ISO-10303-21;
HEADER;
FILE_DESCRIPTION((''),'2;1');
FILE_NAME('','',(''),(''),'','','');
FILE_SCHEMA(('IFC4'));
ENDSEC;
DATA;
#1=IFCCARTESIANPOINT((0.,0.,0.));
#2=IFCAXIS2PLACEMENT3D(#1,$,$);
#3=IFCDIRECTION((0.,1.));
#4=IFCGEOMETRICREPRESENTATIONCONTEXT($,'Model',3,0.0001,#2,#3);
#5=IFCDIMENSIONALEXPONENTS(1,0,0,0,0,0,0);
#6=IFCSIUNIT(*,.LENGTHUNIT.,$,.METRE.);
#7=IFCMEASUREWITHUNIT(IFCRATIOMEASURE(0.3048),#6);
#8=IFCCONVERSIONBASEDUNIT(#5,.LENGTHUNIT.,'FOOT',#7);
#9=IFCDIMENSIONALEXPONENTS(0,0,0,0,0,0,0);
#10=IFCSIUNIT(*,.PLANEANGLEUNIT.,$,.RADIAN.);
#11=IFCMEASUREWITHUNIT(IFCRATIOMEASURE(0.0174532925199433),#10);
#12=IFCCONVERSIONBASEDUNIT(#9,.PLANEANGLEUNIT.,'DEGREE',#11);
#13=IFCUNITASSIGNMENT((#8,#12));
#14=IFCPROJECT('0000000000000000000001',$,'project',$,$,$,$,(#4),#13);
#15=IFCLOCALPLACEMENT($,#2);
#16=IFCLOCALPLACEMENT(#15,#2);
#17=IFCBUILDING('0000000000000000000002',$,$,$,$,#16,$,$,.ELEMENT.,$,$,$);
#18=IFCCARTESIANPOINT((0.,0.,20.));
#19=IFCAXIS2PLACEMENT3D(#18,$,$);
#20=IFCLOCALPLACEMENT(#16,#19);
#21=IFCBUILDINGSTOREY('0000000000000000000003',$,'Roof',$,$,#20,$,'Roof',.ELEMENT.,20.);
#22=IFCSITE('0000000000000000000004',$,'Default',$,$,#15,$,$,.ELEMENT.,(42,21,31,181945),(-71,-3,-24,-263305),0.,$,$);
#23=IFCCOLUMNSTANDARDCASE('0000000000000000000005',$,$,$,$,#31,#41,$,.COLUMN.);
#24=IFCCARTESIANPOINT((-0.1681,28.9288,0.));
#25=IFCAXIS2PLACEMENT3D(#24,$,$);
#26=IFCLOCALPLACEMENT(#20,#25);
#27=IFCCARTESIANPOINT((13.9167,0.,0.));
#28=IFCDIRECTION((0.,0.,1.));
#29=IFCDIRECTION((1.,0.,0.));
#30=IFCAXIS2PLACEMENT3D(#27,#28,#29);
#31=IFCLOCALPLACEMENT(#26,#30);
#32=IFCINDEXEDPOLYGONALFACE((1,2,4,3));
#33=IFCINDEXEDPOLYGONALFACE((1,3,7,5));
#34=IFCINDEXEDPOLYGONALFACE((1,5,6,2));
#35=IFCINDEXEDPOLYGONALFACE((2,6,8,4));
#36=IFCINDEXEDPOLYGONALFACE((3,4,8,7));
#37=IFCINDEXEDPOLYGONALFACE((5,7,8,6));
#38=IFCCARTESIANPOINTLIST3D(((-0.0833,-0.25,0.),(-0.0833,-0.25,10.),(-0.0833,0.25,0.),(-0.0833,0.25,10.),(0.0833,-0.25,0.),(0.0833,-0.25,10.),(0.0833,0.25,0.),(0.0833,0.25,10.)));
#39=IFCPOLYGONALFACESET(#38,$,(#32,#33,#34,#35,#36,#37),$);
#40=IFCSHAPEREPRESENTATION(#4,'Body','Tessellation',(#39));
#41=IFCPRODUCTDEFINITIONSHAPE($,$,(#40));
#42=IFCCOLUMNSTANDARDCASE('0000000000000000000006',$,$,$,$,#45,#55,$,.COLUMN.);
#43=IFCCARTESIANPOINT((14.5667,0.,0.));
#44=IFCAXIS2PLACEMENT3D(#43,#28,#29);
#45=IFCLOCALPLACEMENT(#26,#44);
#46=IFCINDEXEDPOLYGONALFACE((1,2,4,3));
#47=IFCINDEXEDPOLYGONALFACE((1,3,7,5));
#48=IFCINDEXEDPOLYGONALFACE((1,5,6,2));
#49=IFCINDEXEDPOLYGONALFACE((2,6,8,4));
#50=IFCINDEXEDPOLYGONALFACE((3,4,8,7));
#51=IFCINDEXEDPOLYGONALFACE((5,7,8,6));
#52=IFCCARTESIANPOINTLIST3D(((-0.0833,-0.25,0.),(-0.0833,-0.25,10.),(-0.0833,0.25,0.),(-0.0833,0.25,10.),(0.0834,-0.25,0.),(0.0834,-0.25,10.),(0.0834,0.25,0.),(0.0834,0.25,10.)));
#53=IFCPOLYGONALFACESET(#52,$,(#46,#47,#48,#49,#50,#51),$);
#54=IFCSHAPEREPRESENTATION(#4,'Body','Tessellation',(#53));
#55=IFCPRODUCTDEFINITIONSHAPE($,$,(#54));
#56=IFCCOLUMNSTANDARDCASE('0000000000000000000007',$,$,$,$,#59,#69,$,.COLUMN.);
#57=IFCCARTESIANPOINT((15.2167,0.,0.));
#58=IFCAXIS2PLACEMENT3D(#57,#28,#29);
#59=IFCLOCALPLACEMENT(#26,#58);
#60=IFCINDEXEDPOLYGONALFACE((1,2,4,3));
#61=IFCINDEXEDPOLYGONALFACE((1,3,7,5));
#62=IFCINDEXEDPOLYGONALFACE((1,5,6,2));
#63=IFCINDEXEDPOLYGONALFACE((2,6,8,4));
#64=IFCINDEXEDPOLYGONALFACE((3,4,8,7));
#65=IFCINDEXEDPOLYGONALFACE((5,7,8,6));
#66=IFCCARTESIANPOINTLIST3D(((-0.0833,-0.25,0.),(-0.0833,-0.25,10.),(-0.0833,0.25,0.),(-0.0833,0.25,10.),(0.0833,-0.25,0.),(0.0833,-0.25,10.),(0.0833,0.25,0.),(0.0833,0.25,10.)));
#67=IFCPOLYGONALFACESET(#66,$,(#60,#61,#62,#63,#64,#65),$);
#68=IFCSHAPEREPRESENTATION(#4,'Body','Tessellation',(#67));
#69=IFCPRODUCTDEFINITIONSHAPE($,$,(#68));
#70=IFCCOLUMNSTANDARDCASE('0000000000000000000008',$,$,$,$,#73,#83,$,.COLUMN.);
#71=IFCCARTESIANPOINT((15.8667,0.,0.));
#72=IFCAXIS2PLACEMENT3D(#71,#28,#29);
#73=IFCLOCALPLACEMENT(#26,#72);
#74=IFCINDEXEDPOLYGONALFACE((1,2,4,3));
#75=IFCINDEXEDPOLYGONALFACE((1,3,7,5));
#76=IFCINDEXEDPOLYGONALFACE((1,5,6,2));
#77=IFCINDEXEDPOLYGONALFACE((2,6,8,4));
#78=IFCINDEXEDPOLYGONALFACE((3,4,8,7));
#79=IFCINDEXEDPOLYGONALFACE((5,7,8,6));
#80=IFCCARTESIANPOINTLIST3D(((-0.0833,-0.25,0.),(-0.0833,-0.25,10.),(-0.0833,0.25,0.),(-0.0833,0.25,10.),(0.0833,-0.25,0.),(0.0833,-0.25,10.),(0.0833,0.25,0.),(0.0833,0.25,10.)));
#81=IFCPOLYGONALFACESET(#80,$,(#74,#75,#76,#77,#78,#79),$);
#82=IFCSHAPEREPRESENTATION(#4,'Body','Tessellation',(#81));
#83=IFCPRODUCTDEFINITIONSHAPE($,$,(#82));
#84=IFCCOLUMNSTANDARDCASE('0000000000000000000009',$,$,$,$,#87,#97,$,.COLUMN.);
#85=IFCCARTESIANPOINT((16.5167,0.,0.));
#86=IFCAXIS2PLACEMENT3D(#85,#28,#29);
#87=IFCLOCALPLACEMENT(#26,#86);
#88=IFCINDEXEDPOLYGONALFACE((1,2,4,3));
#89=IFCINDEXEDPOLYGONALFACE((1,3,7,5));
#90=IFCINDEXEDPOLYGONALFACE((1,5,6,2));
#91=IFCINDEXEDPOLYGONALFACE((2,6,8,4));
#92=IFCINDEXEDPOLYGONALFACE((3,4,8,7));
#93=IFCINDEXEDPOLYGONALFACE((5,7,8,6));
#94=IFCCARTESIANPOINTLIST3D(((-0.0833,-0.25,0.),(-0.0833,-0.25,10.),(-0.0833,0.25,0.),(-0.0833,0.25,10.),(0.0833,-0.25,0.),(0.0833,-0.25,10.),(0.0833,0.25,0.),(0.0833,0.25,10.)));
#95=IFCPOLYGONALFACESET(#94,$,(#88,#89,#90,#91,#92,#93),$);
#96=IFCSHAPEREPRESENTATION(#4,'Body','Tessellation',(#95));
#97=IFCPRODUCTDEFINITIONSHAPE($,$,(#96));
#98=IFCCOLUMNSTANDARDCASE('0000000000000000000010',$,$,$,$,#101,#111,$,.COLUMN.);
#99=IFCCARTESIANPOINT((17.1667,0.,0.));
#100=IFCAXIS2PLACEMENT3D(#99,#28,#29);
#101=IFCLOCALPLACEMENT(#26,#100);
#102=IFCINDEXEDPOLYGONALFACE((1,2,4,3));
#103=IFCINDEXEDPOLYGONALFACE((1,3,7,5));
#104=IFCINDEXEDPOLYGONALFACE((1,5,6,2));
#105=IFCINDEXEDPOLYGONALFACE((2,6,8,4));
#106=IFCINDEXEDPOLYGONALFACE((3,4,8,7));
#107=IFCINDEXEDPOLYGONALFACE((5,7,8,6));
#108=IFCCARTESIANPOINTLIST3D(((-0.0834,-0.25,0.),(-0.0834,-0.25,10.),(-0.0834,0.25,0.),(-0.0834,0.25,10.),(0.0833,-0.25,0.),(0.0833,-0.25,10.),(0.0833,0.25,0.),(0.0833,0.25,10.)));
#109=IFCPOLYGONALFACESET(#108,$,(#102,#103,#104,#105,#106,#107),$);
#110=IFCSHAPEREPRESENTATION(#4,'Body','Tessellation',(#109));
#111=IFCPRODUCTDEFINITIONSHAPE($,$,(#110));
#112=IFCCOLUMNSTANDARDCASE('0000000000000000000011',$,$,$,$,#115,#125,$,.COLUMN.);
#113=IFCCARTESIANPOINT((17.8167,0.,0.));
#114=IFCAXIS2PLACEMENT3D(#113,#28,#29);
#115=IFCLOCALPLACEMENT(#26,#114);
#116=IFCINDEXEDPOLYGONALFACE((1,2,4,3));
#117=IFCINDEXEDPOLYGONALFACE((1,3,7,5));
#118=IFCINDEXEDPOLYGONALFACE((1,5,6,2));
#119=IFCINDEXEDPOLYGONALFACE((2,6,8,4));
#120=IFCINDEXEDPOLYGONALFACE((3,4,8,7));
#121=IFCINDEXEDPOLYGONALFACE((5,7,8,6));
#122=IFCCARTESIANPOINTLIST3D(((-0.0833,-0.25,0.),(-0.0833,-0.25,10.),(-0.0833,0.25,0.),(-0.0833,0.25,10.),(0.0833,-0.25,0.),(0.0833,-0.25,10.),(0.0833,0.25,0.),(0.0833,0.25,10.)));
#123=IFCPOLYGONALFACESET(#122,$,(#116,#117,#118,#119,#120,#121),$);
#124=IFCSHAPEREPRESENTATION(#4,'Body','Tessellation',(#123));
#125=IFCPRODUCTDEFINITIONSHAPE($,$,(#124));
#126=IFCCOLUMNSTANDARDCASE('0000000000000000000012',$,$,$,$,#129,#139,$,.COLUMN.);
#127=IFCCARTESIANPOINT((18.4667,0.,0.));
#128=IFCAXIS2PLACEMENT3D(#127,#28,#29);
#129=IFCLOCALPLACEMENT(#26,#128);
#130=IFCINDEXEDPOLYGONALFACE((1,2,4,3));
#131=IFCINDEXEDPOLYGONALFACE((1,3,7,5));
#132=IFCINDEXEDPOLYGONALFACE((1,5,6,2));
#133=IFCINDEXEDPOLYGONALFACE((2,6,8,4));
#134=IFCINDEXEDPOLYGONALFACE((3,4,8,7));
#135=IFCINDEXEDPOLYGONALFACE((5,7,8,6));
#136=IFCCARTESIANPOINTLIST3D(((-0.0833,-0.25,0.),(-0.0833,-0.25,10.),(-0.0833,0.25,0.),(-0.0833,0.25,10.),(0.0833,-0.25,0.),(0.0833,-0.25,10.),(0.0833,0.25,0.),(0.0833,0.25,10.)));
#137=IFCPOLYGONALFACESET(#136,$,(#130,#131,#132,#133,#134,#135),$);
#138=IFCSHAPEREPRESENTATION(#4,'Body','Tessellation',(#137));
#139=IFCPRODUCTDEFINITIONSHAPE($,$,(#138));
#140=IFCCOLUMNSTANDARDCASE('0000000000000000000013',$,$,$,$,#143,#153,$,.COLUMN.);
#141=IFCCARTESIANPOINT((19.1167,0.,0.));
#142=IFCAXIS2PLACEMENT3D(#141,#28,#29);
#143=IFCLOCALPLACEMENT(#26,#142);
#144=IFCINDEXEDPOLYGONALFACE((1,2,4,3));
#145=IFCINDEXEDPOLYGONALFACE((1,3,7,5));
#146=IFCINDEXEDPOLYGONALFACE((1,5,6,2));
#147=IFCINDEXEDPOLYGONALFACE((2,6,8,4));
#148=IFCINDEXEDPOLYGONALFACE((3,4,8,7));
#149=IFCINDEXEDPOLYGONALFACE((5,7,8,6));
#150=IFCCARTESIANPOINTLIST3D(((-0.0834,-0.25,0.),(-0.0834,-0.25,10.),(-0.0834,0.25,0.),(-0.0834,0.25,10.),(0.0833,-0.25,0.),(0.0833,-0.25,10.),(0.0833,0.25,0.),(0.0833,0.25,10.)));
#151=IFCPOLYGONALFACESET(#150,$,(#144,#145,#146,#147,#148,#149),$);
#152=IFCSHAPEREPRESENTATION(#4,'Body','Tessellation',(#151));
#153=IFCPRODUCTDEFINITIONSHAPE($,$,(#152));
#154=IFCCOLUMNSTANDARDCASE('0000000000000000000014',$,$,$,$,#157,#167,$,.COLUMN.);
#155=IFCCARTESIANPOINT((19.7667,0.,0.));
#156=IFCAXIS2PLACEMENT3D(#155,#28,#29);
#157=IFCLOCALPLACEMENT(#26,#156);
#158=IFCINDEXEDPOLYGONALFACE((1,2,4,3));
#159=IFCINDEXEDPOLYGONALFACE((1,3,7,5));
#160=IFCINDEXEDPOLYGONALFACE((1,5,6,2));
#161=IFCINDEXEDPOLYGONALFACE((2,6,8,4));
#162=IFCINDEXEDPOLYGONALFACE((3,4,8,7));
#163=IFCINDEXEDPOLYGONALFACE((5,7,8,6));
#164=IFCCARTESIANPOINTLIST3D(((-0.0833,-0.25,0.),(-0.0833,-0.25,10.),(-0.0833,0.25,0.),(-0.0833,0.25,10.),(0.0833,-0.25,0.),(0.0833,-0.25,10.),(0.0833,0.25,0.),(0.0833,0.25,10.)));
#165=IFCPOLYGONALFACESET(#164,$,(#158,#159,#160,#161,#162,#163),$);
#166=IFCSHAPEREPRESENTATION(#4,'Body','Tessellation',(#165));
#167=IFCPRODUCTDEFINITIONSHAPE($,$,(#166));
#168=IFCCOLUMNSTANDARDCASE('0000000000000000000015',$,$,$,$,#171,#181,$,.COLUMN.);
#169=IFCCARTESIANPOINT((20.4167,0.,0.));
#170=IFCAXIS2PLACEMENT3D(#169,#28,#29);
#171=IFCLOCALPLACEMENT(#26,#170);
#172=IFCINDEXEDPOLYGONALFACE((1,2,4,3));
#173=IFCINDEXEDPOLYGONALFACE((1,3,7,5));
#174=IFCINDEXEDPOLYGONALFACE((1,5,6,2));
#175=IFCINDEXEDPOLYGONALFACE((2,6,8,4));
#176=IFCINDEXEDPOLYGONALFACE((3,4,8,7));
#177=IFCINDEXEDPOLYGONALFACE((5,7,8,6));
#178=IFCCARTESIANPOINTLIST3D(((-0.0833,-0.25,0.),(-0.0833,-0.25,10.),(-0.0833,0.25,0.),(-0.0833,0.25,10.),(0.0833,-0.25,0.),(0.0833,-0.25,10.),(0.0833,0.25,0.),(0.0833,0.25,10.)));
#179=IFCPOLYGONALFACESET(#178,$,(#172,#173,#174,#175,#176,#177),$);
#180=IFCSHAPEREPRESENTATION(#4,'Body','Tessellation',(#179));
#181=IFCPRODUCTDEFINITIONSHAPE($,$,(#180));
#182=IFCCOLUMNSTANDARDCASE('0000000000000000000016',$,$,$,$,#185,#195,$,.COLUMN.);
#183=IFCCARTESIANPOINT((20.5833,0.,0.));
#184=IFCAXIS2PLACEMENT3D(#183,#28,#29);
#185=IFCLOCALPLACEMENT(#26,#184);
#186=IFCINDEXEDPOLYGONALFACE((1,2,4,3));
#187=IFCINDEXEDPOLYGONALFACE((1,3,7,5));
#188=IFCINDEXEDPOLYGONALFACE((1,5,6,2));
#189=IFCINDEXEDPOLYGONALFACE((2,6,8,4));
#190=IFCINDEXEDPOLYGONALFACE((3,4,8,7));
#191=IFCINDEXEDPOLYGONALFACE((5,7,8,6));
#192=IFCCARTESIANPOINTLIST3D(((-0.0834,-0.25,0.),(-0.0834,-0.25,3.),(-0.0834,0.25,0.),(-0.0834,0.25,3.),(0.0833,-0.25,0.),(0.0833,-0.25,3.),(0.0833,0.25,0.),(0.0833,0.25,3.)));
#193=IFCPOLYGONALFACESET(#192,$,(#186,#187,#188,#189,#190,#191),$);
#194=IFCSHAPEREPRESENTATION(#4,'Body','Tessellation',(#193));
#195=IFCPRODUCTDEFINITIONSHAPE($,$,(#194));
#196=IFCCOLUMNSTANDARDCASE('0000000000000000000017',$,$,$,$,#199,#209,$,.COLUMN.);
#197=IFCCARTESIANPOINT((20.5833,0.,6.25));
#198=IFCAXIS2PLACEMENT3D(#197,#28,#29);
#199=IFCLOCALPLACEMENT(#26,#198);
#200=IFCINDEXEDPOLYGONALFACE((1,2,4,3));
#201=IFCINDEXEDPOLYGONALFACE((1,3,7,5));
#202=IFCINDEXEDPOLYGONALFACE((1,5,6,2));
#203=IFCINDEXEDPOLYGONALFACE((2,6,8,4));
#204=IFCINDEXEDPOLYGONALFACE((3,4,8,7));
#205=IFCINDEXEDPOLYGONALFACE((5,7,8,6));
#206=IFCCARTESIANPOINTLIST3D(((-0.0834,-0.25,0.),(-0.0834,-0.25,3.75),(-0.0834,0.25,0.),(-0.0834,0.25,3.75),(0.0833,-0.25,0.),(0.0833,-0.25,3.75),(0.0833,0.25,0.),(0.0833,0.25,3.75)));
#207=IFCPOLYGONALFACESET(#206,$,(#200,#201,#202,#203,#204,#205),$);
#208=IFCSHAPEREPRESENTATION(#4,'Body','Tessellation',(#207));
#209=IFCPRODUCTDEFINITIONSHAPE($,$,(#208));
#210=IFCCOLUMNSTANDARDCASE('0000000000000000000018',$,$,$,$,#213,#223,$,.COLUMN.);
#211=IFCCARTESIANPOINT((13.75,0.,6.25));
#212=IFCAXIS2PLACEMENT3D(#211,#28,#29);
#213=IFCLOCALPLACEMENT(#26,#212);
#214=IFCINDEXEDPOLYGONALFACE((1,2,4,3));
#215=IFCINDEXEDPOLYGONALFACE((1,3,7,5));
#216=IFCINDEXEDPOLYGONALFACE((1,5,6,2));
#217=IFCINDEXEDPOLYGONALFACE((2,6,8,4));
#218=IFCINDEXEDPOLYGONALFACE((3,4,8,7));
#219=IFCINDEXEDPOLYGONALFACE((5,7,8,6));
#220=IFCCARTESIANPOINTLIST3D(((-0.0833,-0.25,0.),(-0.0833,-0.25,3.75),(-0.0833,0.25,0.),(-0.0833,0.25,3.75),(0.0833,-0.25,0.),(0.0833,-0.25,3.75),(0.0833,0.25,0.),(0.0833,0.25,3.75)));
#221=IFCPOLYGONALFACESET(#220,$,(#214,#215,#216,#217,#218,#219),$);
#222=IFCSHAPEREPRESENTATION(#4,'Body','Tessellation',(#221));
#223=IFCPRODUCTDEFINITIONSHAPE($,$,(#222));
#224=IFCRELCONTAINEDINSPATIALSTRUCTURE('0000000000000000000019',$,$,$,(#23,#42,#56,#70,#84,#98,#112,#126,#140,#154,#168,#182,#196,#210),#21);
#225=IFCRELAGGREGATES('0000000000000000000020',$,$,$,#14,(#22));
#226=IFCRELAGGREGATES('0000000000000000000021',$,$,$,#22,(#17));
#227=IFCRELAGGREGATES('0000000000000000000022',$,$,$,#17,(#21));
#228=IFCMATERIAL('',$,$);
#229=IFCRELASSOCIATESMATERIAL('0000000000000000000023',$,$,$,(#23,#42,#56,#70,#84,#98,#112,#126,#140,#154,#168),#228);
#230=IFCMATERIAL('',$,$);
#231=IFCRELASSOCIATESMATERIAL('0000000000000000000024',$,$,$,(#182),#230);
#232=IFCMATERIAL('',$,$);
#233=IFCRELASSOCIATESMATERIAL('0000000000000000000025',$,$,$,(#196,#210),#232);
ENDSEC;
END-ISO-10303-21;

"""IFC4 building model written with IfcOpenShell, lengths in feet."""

from ifc_helpers import new_model, entity, si_unit, converted_unit, direction, frame, origin, place, context, project, spatial, rectangle, extrude, material, element, save


model = new_model("IFC4")

# Units and contexts
model_context = context("Model", 3, precision=0.0001, world=origin(), true_north=direction((0.0, 1.0)))
ifc_project = project(units=[converted_unit("LENGTHUNIT", "FOOT", entity("IfcRatioMeasure", 0.3048), si_unit("LENGTHUNIT", "METRE"), dimensions=[1, 0, 0, 0, 0, 0, 0]), converted_unit("PLANEANGLEUNIT", "DEGREE", entity("IfcRatioMeasure", 0.0174532925199433), si_unit("PLANEANGLEUNIT", "RADIAN"), dimensions=[0, 0, 0, 0, 0, 0, 0])], contexts=[model_context])

# Site, building, storey
site_placement = place(None, origin())
site = spatial("IfcSite", under=ifc_project, at=site_placement, Name="Default", CompositionType="ELEMENT", RefLatitude=(42, 21, 31, 181945), RefLongitude=(-71, -3, -24, -263305), RefElevation=0.0)
building_placement = place(site_placement, origin())
building = spatial("IfcBuilding", under=site, at=building_placement, CompositionType="ELEMENT")
storey_placement = place(building_placement, frame((0.0, 0.0, 20.0)))
storey = spatial("IfcBuildingStorey", under=building, at=storey_placement, Name="Roof", LongName="Roof", CompositionType="ELEMENT", Elevation=20.0)

# Columns
ifc_material_1 = material(Name="")
placement = place(storey_placement, frame((-0.1681, 28.9288, 0.0)))
for number, where, z_axis, x_axis in (
    (1, (13.9167, 0.0, 0.0), (0.0, 0.0, 1.0), (1.0, 0.0, 0.0)),
    (2, (14.5667, 0.0, 0.0), (0.0, 0.0, 1.0), (1.0, 0.0, 0.0)),
    (3, (15.2167, 0.0, 0.0), (0.0, 0.0, 1.0), (1.0, 0.0, 0.0)),
    (4, (15.8667, 0.0, 0.0), (0.0, 0.0, 1.0), (1.0, 0.0, 0.0)),
    (5, (16.5167, 0.0, 0.0), (0.0, 0.0, 1.0), (1.0, 0.0, 0.0)),
    (6, (17.1667, 0.0, 0.0), (0.0, 0.0, 1.0), (1.0, 0.0, 0.0)),
    (7, (17.8167, 0.0, 0.0), (0.0, 0.0, 1.0), (1.0, 0.0, 0.0)),
    (8, (18.4667, 0.0, 0.0), (0.0, 0.0, 1.0), (1.0, 0.0, 0.0)),
    (9, (19.1167, 0.0, 0.0), (0.0, 0.0, 1.0), (1.0, 0.0, 0.0)),
    (10, (19.7667, 0.0, 0.0), (0.0, 0.0, 1.0), (1.0, 0.0, 0.0)),
    (11, (20.4167, 0.0, 0.0), (0.0, 0.0, 1.0), (1.0, 0.0, 0.0)),
):
    element("IfcColumnStandardCase", number, at=place(placement, frame(where, z_axis=z_axis, x_axis=x_axis)), inside=storey, material=ifc_material_1, PredefinedType="COLUMN", context=model_context, shape_type="SweptSolid", body=[
        extrude(rectangle(XDim=0.1667, YDim=0.5), origin(), (0.0, 0.0, 1.0), 10.0),
    ])
ifc_material_2 = material(Name="")
for number, where, z_axis, x_axis in (
    (12, (20.5833, 0.0, 0.0), (0.0, 0.0, 1.0), (1.0, 0.0, 0.0)),
):
    element("IfcColumnStandardCase", number, at=place(placement, frame(where, z_axis=z_axis, x_axis=x_axis)), inside=storey, material=ifc_material_2, PredefinedType="COLUMN", context=model_context, shape_type="SweptSolid", body=[
        extrude(rectangle(XDim=0.1667, YDim=0.5), origin(), (0.0, 0.0, 1.0), 3.0),
    ])
ifc_material_3 = material(Name="")
for number, where, z_axis, x_axis in (
    (13, (20.5833, 0.0, 6.25), (0.0, 0.0, 1.0), (1.0, 0.0, 0.0)),
    (14, (13.75, 0.0, 6.25), (0.0, 0.0, 1.0), (1.0, 0.0, 0.0)),
):
    element("IfcColumnStandardCase", number, at=place(placement, frame(where, z_axis=z_axis, x_axis=x_axis)), inside=storey, material=ifc_material_3, PredefinedType="COLUMN", context=model_context, shape_type="SweptSolid", body=[
        extrude(rectangle(XDim=0.1667, YDim=0.5), origin(), (0.0, 0.0, 1.0), 3.75),
    ])

save(model, "model.ifc")
